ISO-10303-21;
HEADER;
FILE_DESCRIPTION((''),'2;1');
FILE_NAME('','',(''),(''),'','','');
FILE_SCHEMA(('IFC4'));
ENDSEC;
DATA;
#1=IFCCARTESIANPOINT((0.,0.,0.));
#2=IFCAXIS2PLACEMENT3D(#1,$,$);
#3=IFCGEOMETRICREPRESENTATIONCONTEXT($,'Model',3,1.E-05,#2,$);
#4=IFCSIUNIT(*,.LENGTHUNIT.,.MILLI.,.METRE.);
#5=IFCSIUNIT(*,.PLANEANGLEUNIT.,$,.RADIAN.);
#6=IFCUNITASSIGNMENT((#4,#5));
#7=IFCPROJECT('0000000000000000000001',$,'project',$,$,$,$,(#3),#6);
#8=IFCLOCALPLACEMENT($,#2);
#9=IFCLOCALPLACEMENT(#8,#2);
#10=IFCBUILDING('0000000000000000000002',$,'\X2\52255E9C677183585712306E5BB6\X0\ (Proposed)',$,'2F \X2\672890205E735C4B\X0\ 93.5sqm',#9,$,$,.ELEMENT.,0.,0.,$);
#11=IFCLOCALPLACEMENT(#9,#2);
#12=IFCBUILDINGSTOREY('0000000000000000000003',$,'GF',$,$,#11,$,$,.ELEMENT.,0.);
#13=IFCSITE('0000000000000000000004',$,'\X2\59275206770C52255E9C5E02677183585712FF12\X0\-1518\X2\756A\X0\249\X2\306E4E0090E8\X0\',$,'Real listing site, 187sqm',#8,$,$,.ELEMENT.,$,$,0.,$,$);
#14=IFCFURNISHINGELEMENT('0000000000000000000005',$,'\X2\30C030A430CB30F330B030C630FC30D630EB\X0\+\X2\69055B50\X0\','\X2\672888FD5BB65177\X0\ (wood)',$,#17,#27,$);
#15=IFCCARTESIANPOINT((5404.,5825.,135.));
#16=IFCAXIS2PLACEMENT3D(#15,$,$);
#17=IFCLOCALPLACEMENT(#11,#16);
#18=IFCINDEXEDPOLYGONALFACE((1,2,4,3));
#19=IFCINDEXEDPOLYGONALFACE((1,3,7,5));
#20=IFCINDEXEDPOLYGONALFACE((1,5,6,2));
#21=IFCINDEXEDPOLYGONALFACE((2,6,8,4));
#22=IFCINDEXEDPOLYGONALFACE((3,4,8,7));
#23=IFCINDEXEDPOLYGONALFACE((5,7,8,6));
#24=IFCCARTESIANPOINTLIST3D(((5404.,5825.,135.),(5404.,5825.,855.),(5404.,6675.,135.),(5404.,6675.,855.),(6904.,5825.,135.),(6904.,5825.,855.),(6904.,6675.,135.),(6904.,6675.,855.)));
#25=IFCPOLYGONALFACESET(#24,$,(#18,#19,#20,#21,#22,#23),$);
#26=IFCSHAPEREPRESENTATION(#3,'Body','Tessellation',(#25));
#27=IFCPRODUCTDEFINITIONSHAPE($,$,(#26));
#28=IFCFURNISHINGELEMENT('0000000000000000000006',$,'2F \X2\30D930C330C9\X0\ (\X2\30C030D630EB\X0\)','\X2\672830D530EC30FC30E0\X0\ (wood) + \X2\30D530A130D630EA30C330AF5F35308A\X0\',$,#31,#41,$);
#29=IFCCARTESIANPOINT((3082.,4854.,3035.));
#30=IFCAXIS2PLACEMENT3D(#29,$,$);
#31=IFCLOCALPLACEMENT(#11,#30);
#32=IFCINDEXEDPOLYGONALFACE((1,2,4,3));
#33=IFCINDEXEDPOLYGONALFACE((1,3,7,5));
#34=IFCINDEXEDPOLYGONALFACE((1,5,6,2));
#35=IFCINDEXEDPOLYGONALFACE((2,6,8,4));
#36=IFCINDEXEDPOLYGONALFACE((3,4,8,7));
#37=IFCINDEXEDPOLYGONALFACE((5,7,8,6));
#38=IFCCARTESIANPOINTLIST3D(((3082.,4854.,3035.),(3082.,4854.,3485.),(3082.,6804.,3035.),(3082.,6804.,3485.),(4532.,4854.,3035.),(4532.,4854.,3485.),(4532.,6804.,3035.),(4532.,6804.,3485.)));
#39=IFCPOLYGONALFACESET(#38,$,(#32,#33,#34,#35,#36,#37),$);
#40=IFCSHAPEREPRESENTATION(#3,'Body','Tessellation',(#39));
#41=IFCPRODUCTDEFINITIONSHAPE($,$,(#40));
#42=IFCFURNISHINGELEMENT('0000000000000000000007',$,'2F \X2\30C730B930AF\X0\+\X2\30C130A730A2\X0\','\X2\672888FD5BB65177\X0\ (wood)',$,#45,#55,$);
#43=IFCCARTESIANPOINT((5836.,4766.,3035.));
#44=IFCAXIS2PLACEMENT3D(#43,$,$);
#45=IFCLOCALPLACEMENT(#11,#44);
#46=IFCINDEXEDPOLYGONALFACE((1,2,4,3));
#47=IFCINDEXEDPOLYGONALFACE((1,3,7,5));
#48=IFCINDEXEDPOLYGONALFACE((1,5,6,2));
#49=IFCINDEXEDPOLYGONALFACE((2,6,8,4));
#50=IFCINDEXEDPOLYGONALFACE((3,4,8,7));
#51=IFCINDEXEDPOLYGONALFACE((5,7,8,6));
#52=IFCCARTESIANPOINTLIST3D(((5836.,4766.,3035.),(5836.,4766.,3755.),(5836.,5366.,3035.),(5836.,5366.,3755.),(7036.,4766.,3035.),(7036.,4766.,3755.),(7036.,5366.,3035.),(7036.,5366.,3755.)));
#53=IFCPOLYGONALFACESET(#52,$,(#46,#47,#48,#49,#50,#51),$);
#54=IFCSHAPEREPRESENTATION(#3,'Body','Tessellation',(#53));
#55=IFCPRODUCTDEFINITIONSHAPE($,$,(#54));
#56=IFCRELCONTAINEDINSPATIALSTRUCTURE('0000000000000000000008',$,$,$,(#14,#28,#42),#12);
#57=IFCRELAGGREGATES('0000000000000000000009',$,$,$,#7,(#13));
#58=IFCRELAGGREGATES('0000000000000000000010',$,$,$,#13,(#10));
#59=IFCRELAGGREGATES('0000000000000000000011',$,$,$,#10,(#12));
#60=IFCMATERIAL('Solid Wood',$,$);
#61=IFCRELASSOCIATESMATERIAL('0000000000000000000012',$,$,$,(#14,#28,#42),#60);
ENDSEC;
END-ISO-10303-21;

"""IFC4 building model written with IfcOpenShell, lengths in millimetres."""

from ifc_helpers import new_model, si_unit, frame, frame_2d, origin, place, context, project, spatial, rectangle, extrude, material, element, save


model = new_model("IFC4")

# Units and contexts
model_context = context("Model", 3, precision=1e-05, world=origin())
ifc_project = project(units=[si_unit("LENGTHUNIT", "METRE", prefix="MILLI"), si_unit("PLANEANGLEUNIT", "RADIAN")], contexts=[model_context])

# Site, building, storey
site_placement = place(None, origin())
site = spatial("IfcSite", under=ifc_project, at=site_placement, Name="大分県別府市東荘園２-1518番249の一部", ObjectType="Real listing site, 187sqm", CompositionType="ELEMENT", RefElevation=0.0)
building_placement = place(site_placement, origin())
building = spatial("IfcBuilding", under=site, at=building_placement, Name="別府東荘園の家 (Proposed)", ObjectType="2F 木造平屋 93.5sqm", CompositionType="ELEMENT", ElevationOfRefHeight=0.0, ElevationOfTerrain=0.0)
storey_placement = place(building_placement, origin())
storey = spatial("IfcBuildingStorey", under=building, at=storey_placement, Name="GF", CompositionType="ELEMENT", Elevation=0.0)

# Shared definitions
ifc_material_1 = material(Name="Solid Wood")

# Furnishing elements
furnishing_1_placement = place(storey_placement, frame((5404.0, 5825.0, 135.0)))
element("IfcFurnishingElement", 1, at=furnishing_1_placement, inside=storey, material=ifc_material_1, Name="ダイニングテーブル+椅子", Description="木製家具 (wood)", context=model_context, shape_type="SweptSolid", body=[
    extrude(rectangle(XDim=1500.0, YDim=850.0, at=frame_2d((750.0, 425.0))), frame((5404.0, 5825.0, 135.0)), (0.0, 0.0, 1.0), 720.0),
])
furnishing_2_placement = place(storey_placement, frame((3082.0, 4854.0, 3035.0)))
element("IfcFurnishingElement", 2, at=furnishing_2_placement, inside=storey, material=ifc_material_1, Name="2F ベッド (ダブル)", Description="木フレーム (wood) + ファブリック張り", context=model_context, shape_type="SweptSolid", body=[
    extrude(rectangle(XDim=1450.0, YDim=1950.0, at=frame_2d((725.0, 975.0))), frame((3082.0, 4854.0, 3035.0)), (0.0, 0.0, 1.0), 450.0),
])
furnishing_3_placement = place(storey_placement, frame((5836.0, 4766.0, 3035.0)))
element("IfcFurnishingElement", 3, at=furnishing_3_placement, inside=storey, material=ifc_material_1, Name="2F デスク+チェア", Description="木製家具 (wood)", context=model_context, shape_type="SweptSolid", body=[
    extrude(rectangle(XDim=1200.0, YDim=600.0, at=frame_2d((600.0, 300.0))), frame((5836.0, 4766.0, 3035.0)), (0.0, 0.0, 1.0), 720.0),
])

save(model, "model.ifc")
